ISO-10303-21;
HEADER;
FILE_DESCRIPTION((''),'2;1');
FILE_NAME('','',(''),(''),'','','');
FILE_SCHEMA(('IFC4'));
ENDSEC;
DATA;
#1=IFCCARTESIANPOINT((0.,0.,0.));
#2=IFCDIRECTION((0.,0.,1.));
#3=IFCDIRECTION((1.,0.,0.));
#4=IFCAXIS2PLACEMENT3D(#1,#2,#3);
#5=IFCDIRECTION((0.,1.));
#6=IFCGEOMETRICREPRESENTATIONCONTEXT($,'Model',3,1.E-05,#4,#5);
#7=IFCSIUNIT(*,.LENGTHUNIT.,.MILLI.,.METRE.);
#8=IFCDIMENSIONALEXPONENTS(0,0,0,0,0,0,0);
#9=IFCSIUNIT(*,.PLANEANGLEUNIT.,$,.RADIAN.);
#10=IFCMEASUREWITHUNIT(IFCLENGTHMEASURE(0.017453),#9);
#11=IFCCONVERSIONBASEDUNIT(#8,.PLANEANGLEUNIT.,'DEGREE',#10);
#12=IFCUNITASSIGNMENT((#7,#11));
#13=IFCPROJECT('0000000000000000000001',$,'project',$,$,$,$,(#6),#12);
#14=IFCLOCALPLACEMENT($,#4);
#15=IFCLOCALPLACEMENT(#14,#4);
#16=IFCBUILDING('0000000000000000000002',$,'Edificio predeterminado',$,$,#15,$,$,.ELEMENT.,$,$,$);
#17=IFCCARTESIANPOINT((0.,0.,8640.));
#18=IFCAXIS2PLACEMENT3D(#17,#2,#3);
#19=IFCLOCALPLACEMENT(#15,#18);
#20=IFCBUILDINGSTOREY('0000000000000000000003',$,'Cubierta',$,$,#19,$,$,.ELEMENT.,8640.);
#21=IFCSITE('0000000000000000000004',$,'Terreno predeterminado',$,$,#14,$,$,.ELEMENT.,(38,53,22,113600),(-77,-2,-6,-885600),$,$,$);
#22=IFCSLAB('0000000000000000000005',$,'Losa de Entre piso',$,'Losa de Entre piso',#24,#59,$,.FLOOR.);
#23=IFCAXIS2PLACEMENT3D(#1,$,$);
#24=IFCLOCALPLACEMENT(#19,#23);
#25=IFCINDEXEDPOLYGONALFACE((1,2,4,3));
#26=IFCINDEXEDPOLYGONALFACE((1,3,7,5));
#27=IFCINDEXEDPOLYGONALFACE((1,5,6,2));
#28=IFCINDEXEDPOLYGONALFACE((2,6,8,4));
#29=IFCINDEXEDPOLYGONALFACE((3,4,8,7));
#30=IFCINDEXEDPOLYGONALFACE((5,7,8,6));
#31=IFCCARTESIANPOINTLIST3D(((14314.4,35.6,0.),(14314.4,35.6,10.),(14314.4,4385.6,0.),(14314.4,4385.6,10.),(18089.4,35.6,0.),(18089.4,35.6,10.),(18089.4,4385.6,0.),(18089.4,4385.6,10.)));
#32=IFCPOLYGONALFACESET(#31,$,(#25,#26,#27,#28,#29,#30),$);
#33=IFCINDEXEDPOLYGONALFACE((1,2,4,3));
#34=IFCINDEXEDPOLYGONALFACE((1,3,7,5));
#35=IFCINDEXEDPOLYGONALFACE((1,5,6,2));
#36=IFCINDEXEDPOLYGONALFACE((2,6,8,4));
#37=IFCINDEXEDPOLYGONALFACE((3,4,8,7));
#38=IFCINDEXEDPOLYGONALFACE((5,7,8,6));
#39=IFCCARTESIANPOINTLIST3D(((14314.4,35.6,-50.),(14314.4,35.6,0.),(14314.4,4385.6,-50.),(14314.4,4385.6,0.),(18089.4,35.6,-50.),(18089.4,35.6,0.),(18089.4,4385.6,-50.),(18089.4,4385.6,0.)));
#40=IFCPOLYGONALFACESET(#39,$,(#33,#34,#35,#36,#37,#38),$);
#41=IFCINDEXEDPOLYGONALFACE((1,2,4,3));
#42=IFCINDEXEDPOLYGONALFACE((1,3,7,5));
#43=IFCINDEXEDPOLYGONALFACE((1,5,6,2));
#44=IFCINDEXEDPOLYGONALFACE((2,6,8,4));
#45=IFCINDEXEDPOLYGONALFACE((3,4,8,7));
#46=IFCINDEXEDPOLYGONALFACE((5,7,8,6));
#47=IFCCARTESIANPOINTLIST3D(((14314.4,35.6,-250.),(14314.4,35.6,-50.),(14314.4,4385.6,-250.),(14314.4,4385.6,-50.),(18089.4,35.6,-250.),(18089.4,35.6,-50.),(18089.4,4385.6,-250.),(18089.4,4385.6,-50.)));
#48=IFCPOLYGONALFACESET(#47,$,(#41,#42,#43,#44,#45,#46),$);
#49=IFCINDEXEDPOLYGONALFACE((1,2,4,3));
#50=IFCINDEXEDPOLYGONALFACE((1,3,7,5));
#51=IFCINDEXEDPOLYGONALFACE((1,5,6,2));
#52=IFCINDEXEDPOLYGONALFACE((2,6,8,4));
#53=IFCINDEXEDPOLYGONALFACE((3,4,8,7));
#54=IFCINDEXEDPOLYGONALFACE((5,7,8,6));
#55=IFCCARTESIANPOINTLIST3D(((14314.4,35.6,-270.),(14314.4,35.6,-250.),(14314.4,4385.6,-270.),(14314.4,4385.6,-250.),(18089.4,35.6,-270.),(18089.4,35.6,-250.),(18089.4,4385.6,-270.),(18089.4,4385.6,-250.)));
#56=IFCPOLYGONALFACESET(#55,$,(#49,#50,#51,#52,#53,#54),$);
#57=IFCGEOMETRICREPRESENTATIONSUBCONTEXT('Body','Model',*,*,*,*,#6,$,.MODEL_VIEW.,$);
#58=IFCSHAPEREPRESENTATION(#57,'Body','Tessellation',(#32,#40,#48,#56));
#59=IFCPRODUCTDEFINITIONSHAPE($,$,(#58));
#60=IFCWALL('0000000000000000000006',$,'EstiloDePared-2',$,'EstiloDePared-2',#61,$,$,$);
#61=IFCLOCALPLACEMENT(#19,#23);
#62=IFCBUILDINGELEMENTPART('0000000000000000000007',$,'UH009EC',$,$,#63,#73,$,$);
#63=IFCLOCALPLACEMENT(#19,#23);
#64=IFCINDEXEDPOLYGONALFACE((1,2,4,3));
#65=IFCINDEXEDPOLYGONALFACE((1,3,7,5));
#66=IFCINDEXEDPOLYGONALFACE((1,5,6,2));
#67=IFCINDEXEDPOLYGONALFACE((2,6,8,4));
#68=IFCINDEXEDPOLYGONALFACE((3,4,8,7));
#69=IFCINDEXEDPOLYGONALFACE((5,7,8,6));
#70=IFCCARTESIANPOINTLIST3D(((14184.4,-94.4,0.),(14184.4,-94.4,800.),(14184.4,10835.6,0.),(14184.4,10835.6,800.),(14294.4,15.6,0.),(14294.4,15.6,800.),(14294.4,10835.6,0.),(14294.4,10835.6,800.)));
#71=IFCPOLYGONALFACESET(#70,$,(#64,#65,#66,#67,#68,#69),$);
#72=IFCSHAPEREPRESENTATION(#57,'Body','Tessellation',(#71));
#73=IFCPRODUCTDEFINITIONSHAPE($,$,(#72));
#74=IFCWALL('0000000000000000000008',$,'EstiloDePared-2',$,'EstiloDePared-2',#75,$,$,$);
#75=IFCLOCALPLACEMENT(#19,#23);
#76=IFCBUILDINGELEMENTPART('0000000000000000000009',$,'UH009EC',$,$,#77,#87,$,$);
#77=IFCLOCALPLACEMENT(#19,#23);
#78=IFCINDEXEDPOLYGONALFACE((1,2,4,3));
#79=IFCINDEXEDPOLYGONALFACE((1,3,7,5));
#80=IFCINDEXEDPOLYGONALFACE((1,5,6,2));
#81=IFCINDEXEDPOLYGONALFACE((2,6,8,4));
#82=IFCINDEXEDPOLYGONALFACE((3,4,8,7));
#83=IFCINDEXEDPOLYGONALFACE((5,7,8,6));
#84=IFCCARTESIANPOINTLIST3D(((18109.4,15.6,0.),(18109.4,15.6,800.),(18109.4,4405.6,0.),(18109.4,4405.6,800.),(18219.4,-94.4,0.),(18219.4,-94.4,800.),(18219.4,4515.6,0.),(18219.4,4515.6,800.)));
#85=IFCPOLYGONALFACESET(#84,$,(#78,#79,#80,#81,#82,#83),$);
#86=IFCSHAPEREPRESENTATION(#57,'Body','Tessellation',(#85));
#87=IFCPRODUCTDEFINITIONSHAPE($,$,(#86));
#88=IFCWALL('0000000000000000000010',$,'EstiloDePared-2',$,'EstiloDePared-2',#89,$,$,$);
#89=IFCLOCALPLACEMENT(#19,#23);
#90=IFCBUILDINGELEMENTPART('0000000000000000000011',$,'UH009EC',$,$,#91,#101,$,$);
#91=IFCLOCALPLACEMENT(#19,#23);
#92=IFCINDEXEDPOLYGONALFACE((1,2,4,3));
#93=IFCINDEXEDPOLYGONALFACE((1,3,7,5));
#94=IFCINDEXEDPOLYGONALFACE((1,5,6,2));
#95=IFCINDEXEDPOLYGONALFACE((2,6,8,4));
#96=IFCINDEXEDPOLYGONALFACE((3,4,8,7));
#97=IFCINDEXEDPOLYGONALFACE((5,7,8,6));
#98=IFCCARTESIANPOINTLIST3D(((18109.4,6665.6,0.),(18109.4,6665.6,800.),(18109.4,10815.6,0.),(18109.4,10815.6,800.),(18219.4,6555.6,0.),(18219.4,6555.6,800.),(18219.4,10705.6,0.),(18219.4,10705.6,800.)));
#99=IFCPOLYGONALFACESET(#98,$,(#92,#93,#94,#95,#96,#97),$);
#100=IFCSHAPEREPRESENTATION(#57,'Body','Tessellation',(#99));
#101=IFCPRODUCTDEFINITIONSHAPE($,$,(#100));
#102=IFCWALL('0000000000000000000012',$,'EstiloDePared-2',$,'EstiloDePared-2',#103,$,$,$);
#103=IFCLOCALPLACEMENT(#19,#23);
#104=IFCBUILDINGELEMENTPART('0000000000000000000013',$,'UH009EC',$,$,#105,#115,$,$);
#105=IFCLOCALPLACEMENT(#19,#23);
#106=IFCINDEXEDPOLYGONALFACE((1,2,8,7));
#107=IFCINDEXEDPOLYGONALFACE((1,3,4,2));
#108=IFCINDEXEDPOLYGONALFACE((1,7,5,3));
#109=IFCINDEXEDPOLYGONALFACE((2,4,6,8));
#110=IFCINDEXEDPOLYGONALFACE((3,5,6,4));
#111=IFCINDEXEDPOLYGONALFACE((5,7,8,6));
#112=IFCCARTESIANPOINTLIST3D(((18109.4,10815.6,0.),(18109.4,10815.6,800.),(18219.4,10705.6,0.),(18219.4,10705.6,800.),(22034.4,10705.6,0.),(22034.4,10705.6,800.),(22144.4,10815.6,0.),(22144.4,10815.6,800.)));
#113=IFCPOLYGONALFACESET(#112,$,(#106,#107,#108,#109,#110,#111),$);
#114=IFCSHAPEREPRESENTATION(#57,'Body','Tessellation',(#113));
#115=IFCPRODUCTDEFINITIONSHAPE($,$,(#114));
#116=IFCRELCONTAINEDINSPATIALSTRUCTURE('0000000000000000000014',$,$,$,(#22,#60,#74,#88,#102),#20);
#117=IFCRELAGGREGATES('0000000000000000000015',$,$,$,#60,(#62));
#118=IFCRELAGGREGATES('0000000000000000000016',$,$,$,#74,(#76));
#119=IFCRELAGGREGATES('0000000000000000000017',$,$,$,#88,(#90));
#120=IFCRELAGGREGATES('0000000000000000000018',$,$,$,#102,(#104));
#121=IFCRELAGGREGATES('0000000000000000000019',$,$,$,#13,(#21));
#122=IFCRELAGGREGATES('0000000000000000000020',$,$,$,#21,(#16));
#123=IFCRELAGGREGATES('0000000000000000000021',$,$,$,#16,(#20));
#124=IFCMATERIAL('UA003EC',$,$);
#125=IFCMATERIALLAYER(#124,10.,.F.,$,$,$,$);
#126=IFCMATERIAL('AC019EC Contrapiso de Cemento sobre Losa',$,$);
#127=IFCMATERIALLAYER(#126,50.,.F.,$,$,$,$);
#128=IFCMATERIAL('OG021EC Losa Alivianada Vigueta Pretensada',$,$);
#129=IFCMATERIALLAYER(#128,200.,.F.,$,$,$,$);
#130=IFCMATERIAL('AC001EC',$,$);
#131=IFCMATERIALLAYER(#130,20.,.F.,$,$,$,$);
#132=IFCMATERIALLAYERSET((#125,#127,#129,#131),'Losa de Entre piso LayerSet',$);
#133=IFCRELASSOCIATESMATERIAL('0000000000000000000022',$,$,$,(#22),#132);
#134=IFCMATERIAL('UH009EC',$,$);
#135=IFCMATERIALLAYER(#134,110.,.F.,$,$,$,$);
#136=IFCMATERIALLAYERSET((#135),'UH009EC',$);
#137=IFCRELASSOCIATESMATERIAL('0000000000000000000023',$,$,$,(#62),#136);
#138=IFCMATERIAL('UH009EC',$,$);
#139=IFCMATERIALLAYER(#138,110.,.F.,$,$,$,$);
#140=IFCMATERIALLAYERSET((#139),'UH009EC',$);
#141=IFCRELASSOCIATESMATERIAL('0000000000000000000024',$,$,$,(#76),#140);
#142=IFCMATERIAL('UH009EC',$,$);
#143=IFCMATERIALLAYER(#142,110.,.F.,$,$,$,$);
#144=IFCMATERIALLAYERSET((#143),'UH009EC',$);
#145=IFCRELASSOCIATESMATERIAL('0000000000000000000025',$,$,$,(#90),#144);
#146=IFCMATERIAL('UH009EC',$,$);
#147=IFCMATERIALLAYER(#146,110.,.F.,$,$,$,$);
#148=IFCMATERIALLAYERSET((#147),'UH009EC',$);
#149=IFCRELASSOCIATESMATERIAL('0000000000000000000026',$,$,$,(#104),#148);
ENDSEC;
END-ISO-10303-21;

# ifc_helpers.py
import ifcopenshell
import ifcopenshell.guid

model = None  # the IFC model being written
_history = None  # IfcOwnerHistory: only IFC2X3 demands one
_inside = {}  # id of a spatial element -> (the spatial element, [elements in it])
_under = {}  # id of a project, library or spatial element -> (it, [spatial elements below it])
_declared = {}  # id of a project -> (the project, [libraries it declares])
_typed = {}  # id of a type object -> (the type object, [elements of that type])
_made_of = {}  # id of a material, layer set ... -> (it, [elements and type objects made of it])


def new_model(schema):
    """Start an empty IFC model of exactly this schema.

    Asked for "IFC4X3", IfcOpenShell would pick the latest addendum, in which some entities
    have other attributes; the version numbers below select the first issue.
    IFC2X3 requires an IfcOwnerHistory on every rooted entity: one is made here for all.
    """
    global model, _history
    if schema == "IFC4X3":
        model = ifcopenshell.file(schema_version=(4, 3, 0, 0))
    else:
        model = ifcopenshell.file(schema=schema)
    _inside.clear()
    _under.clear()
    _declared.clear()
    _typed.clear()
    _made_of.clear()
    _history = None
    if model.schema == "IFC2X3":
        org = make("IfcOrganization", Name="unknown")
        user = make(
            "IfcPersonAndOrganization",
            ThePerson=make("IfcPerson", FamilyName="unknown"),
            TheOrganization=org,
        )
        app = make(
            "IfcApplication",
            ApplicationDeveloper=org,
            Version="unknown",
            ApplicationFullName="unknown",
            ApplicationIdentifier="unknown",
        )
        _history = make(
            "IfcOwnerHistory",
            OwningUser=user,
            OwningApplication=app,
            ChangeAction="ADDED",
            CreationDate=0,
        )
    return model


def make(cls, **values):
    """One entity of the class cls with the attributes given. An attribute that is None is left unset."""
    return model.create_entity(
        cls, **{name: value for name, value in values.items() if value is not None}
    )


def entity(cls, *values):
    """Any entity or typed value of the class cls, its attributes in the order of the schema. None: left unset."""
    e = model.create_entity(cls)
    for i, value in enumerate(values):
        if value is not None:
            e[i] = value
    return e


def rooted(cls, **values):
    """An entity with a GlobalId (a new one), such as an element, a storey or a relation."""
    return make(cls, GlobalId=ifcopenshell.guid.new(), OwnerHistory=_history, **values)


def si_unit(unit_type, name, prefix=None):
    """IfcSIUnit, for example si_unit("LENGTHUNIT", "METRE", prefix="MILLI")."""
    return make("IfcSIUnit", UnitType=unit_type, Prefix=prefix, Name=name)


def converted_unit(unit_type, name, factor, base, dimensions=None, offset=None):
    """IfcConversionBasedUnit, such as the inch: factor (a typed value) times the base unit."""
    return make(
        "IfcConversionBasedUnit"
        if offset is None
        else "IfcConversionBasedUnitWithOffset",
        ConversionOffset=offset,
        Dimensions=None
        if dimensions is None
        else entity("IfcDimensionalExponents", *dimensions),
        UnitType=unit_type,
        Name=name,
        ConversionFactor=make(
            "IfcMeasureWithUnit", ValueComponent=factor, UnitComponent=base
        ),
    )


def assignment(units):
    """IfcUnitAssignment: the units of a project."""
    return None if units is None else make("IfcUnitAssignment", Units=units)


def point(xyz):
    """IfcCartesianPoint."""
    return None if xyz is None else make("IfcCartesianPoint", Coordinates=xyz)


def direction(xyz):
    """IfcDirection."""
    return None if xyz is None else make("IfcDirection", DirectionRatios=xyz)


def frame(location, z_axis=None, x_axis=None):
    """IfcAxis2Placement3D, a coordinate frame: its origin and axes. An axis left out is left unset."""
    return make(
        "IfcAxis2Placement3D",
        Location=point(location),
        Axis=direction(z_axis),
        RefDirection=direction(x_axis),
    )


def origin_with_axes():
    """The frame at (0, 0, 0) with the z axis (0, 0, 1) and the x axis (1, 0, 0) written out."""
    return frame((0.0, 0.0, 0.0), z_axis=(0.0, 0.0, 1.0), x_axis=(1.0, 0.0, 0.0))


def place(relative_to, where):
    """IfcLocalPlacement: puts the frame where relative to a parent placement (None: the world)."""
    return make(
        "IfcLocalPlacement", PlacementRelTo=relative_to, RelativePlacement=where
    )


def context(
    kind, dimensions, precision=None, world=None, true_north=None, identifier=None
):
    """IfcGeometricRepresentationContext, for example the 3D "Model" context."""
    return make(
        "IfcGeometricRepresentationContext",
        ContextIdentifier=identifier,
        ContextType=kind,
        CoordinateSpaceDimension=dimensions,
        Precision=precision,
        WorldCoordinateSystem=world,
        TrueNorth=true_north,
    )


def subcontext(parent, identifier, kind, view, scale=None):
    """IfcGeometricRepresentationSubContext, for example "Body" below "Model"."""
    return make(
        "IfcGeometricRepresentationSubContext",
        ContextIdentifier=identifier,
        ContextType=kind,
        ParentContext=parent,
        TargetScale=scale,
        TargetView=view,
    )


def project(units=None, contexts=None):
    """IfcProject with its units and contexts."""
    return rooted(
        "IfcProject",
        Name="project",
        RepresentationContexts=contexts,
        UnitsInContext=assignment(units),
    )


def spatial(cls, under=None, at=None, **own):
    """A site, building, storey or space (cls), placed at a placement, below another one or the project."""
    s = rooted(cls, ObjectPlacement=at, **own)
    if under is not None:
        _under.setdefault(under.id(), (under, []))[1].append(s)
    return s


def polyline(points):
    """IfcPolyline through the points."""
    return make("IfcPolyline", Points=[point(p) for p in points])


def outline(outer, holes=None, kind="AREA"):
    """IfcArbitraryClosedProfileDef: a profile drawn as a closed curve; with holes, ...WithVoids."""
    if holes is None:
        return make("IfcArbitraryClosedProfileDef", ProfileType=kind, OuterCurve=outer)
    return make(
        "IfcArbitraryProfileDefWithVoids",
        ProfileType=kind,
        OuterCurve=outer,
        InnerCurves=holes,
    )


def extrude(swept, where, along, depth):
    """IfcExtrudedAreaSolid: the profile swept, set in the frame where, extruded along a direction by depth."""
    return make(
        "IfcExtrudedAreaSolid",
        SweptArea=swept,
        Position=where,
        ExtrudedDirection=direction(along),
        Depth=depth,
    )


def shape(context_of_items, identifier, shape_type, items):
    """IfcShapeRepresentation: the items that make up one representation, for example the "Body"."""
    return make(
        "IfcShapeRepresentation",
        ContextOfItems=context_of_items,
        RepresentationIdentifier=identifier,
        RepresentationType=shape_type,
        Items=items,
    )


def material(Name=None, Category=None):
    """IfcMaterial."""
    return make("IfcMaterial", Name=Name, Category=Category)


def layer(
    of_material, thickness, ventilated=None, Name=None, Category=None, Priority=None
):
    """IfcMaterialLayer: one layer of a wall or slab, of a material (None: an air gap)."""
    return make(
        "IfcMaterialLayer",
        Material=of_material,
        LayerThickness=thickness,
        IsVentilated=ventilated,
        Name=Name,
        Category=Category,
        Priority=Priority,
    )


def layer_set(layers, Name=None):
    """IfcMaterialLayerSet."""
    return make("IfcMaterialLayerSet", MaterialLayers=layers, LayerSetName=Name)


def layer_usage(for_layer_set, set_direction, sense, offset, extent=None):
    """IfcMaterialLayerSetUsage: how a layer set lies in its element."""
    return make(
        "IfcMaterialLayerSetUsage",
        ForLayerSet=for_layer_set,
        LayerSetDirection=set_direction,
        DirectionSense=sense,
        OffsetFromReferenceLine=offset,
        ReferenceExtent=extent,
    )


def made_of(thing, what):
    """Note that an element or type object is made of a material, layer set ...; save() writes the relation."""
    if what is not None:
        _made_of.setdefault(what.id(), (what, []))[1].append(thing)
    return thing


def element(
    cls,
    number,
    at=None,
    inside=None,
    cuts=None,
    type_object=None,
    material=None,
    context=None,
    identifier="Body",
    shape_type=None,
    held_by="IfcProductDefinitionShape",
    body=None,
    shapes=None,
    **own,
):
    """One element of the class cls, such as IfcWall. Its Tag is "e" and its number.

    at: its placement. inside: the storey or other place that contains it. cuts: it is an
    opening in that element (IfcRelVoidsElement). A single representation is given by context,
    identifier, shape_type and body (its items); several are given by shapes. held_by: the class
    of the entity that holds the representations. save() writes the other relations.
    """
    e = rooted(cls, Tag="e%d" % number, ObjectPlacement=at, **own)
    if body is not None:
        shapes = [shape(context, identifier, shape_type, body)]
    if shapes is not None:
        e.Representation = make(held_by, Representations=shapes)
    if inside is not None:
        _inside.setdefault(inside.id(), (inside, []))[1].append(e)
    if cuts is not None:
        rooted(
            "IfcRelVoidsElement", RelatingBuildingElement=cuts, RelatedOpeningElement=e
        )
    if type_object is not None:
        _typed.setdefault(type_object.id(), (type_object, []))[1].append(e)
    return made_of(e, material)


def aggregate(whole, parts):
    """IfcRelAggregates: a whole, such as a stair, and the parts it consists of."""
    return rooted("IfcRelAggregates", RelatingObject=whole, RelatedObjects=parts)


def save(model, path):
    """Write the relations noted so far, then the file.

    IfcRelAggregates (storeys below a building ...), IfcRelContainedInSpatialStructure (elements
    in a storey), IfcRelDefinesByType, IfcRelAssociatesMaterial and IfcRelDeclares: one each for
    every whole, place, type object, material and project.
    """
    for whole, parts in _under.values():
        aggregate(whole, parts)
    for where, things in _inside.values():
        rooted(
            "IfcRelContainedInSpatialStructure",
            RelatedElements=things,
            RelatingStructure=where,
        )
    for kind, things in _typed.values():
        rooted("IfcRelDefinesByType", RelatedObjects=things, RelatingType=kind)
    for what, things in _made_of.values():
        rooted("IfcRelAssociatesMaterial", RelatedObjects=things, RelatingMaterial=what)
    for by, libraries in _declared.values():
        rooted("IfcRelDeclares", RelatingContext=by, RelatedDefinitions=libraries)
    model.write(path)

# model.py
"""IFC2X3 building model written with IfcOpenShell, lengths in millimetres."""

from ifc_helpers import new_model, entity, si_unit, converted_unit, direction, frame, origin_with_axes, place, context, subcontext, project, spatial, polyline, outline, extrude, material, layer, layer_set, layer_usage, element, aggregate, save


model = new_model("IFC2X3")

# Units and contexts
model_context = context("Model", 3, precision=1e-05, world=origin_with_axes(), true_north=direction((0.0, 1.0)))
body_context = subcontext(model_context, "Body", "Model", "MODEL_VIEW")
ifc_project = project(units=[si_unit("LENGTHUNIT", "METRE", prefix="MILLI"), converted_unit("PLANEANGLEUNIT", "DEGREE", entity("IfcLengthMeasure", 0.017453), si_unit("PLANEANGLEUNIT", "RADIAN"), dimensions=[0, 0, 0, 0, 0, 0, 0])], contexts=[model_context])

# Site, building, storey
site_placement = place(None, origin_with_axes())
site = spatial("IfcSite", under=ifc_project, at=site_placement, Name="Terreno predeterminado", CompositionType="ELEMENT", RefLatitude=(38, 53, 22, 113600), RefLongitude=(-77, -2, -6, -885600))
building_placement = place(site_placement, origin_with_axes())
building = spatial("IfcBuilding", under=site, at=building_placement, Name="Edificio predeterminado", CompositionType="ELEMENT")
storey_placement = place(building_placement, frame((0.0, 0.0, 8640.0), z_axis=(0.0, 0.0, 1.0), x_axis=(1.0, 0.0, 0.0)))
storey = spatial("IfcBuildingStorey", under=building, at=storey_placement, Name="Cubierta", CompositionType="ELEMENT", Elevation=8640.0)

# Slab
ifc_material_1 = material(Name="UA003EC")
ifc_layer_1 = layer(ifc_material_1, 10.0, ventilated=False)
ifc_material_2 = material(Name="AC019EC Contrapiso de Cemento sobre Losa")
ifc_layer_2 = layer(ifc_material_2, 50.0, ventilated=False)
ifc_material_3 = material(Name="OG021EC Losa Alivianada Vigueta Pretensada")
ifc_layer_3 = layer(ifc_material_3, 200.0, ventilated=False)
ifc_material_4 = material(Name="AC001EC")
ifc_layer_4 = layer(ifc_material_4, 20.0, ventilated=False)
ifc_layer_set_1 = layer_set([ifc_layer_1, ifc_layer_2, ifc_layer_3, ifc_layer_4], Name="Losa de Entre piso LayerSet")
ifc_layer_usage_1 = layer_usage(ifc_layer_set_1, "AXIS3", "NEGATIVE", 0.0)
slab_1_placement = place(storey_placement, frame((0.0, 0.0, -8640.0), z_axis=(0.0, 0.0, 1.0), x_axis=(1.0, 0.0, 0.0)))
element("IfcSlab", 1, at=slab_1_placement, inside=storey, material=ifc_layer_usage_1, Name="Losa de Entre piso", ObjectType="Losa de Entre piso", PredefinedType="FLOOR", context=body_context, shape_type="SweptSolid", body=[
    extrude(outline(polyline([(0.0, 4350.0), (3775.0, 4350.0), (3775.0, 0.0), (0.0, 0.0), (0.0, 4350.0)])), frame((18089.4, 35.6, 8640.0), z_axis=(0.0, 0.0, -1.0), x_axis=(-1.0, 0.0, 0.0)), (0.0, 0.0, -1.0), 10.0),
    extrude(outline(polyline([(0.0, 4350.0), (3775.0, 4350.0), (3775.0, 0.0), (0.0, 0.0), (0.0, 4350.0)])), frame((18089.4, 35.6, 8590.0), z_axis=(0.0, 0.0, -1.0), x_axis=(-1.0, 0.0, 0.0)), (0.0, 0.0, -1.0), 50.0),
    extrude(outline(polyline([(0.0, 4350.0), (3775.0, 4350.0), (3775.0, 0.0), (0.0, 0.0), (0.0, 4350.0)])), frame((18089.4, 35.6, 8390.0), z_axis=(0.0, 0.0, -1.0), x_axis=(-1.0, 0.0, 0.0)), (0.0, 0.0, -1.0), 200.0),
    extrude(outline(polyline([(0.0, 4350.0), (3775.0, 4350.0), (3775.0, 0.0), (0.0, 0.0), (0.0, 4350.0)])), frame((18089.4, 35.6, 8370.0), z_axis=(0.0, 0.0, -1.0), x_axis=(-1.0, 0.0, 0.0)), (0.0, 0.0, -1.0), 20.0),
])

# Walls, building element parts
wall_1_placement = place(storey_placement, frame((14239.4, -39.4, 0.0), z_axis=(0.0, 0.0, 1.0), x_axis=(0.0, 1.0, 0.0)))
wall_1 = element("IfcWall", 2, at=wall_1_placement, inside=storey, Name="EstiloDePared-2", ObjectType="EstiloDePared-2")
ifc_material_5 = material(Name="UH009EC")
ifc_layer_5 = layer(ifc_material_5, 110.0, ventilated=False)
ifc_layer_set_2 = layer_set([ifc_layer_5], Name="UH009EC")
ifc_layer_usage_2 = layer_usage(ifc_layer_set_2, "AXIS2", "NEGATIVE", -55.0)
building_element_part_1_placement = place(wall_1_placement, origin_with_axes())
building_element_part_1 = element("IfcBuildingElementPart", 3, at=building_element_part_1_placement, material=ifc_layer_usage_2, Name="UH009EC", context=body_context, shape_type="SweptSolid", body=[
    extrude(outline(polyline([(10875.0, 55.0), (10875.0, -55.0), (55.0, -55.0), (-55.0, 55.0), (10875.0, 55.0)])), origin_with_axes(), (0.0, 0.0, 1.0), 800.0),
])
aggregate(wall_1, [building_element_part_1])
wall_2_placement = place(storey_placement, frame((18164.4, -39.4, 0.0), z_axis=(0.0, 0.0, 1.0), x_axis=(0.0, 1.0, 0.0)))
wall_2 = element("IfcWall", 4, at=wall_2_placement, inside=storey, Name="EstiloDePared-2", ObjectType="EstiloDePared-2")
ifc_material_6 = material(Name="UH009EC")
ifc_layer_6 = layer(ifc_material_6, 110.0, ventilated=False)
ifc_layer_set_3 = layer_set([ifc_layer_6], Name="UH009EC")
ifc_layer_usage_3 = layer_usage(ifc_layer_set_3, "AXIS2", "NEGATIVE", -55.0)
building_element_part_2_placement = place(wall_2_placement, origin_with_axes())
building_element_part_2 = element("IfcBuildingElementPart", 5, at=building_element_part_2_placement, material=ifc_layer_usage_3, Name="UH009EC", context=body_context, shape_type="SweptSolid", body=[
    extrude(outline(polyline([(4445.0, 55.0), (4555.0, -55.0), (-55.0, -55.0), (55.0, 55.0), (4445.0, 55.0)])), origin_with_axes(), (0.0, 0.0, 1.0), 800.0),
])
aggregate(wall_2, [building_element_part_2])
wall_3_placement = place(storey_placement, frame((18164.4, 6610.6, 0.0), z_axis=(0.0, 0.0, 1.0), x_axis=(0.0, 1.0, 0.0)))
wall_3 = element("IfcWall", 6, at=wall_3_placement, inside=storey, Name="EstiloDePared-2", ObjectType="EstiloDePared-2")
ifc_material_7 = material(Name="UH009EC")
ifc_layer_7 = layer(ifc_material_7, 110.0, ventilated=False)
ifc_layer_set_4 = layer_set([ifc_layer_7], Name="UH009EC")
ifc_layer_usage_4 = layer_usage(ifc_layer_set_4, "AXIS2", "NEGATIVE", -55.0)
building_element_part_3_placement = place(wall_3_placement, origin_with_axes())
building_element_part_3 = element("IfcBuildingElementPart", 7, at=building_element_part_3_placement, material=ifc_layer_usage_4, Name="UH009EC", context=body_context, shape_type="SweptSolid", body=[
    extrude(outline(polyline([(4205.0, 55.0), (4095.0, -55.0), (-55.0, -55.0), (55.0, 55.0), (4205.0, 55.0)])), origin_with_axes(), (0.0, 0.0, 1.0), 800.0),
])
aggregate(wall_3, [building_element_part_3])
wall_4_placement = place(storey_placement, frame((18164.4, 10760.6, 0.0), z_axis=(0.0, 0.0, 1.0), x_axis=(1.0, 0.0, 0.0)))
wall_4 = element("IfcWall", 8, at=wall_4_placement, inside=storey, Name="EstiloDePared-2", ObjectType="EstiloDePared-2")
ifc_material_8 = material(Name="UH009EC")
ifc_layer_8 = layer(ifc_material_8, 110.0, ventilated=False)
ifc_layer_set_5 = layer_set([ifc_layer_8], Name="UH009EC")
ifc_layer_usage_5 = layer_usage(ifc_layer_set_5, "AXIS2", "NEGATIVE", -55.0)
building_element_part_4_placement = place(wall_4_placement, origin_with_axes())
building_element_part_4 = element("IfcBuildingElementPart", 9, at=building_element_part_4_placement, material=ifc_layer_usage_5, Name="UH009EC", context=body_context, shape_type="SweptSolid", body=[
    extrude(outline(polyline([(3980.0, 55.0), (3870.0, -55.0), (55.0, -55.0), (-55.0, 55.0), (3980.0, 55.0)])), origin_with_axes(), (0.0, 0.0, 1.0), 800.0),
])
aggregate(wall_4, [building_element_part_4])

save(model, "model.ifc")
